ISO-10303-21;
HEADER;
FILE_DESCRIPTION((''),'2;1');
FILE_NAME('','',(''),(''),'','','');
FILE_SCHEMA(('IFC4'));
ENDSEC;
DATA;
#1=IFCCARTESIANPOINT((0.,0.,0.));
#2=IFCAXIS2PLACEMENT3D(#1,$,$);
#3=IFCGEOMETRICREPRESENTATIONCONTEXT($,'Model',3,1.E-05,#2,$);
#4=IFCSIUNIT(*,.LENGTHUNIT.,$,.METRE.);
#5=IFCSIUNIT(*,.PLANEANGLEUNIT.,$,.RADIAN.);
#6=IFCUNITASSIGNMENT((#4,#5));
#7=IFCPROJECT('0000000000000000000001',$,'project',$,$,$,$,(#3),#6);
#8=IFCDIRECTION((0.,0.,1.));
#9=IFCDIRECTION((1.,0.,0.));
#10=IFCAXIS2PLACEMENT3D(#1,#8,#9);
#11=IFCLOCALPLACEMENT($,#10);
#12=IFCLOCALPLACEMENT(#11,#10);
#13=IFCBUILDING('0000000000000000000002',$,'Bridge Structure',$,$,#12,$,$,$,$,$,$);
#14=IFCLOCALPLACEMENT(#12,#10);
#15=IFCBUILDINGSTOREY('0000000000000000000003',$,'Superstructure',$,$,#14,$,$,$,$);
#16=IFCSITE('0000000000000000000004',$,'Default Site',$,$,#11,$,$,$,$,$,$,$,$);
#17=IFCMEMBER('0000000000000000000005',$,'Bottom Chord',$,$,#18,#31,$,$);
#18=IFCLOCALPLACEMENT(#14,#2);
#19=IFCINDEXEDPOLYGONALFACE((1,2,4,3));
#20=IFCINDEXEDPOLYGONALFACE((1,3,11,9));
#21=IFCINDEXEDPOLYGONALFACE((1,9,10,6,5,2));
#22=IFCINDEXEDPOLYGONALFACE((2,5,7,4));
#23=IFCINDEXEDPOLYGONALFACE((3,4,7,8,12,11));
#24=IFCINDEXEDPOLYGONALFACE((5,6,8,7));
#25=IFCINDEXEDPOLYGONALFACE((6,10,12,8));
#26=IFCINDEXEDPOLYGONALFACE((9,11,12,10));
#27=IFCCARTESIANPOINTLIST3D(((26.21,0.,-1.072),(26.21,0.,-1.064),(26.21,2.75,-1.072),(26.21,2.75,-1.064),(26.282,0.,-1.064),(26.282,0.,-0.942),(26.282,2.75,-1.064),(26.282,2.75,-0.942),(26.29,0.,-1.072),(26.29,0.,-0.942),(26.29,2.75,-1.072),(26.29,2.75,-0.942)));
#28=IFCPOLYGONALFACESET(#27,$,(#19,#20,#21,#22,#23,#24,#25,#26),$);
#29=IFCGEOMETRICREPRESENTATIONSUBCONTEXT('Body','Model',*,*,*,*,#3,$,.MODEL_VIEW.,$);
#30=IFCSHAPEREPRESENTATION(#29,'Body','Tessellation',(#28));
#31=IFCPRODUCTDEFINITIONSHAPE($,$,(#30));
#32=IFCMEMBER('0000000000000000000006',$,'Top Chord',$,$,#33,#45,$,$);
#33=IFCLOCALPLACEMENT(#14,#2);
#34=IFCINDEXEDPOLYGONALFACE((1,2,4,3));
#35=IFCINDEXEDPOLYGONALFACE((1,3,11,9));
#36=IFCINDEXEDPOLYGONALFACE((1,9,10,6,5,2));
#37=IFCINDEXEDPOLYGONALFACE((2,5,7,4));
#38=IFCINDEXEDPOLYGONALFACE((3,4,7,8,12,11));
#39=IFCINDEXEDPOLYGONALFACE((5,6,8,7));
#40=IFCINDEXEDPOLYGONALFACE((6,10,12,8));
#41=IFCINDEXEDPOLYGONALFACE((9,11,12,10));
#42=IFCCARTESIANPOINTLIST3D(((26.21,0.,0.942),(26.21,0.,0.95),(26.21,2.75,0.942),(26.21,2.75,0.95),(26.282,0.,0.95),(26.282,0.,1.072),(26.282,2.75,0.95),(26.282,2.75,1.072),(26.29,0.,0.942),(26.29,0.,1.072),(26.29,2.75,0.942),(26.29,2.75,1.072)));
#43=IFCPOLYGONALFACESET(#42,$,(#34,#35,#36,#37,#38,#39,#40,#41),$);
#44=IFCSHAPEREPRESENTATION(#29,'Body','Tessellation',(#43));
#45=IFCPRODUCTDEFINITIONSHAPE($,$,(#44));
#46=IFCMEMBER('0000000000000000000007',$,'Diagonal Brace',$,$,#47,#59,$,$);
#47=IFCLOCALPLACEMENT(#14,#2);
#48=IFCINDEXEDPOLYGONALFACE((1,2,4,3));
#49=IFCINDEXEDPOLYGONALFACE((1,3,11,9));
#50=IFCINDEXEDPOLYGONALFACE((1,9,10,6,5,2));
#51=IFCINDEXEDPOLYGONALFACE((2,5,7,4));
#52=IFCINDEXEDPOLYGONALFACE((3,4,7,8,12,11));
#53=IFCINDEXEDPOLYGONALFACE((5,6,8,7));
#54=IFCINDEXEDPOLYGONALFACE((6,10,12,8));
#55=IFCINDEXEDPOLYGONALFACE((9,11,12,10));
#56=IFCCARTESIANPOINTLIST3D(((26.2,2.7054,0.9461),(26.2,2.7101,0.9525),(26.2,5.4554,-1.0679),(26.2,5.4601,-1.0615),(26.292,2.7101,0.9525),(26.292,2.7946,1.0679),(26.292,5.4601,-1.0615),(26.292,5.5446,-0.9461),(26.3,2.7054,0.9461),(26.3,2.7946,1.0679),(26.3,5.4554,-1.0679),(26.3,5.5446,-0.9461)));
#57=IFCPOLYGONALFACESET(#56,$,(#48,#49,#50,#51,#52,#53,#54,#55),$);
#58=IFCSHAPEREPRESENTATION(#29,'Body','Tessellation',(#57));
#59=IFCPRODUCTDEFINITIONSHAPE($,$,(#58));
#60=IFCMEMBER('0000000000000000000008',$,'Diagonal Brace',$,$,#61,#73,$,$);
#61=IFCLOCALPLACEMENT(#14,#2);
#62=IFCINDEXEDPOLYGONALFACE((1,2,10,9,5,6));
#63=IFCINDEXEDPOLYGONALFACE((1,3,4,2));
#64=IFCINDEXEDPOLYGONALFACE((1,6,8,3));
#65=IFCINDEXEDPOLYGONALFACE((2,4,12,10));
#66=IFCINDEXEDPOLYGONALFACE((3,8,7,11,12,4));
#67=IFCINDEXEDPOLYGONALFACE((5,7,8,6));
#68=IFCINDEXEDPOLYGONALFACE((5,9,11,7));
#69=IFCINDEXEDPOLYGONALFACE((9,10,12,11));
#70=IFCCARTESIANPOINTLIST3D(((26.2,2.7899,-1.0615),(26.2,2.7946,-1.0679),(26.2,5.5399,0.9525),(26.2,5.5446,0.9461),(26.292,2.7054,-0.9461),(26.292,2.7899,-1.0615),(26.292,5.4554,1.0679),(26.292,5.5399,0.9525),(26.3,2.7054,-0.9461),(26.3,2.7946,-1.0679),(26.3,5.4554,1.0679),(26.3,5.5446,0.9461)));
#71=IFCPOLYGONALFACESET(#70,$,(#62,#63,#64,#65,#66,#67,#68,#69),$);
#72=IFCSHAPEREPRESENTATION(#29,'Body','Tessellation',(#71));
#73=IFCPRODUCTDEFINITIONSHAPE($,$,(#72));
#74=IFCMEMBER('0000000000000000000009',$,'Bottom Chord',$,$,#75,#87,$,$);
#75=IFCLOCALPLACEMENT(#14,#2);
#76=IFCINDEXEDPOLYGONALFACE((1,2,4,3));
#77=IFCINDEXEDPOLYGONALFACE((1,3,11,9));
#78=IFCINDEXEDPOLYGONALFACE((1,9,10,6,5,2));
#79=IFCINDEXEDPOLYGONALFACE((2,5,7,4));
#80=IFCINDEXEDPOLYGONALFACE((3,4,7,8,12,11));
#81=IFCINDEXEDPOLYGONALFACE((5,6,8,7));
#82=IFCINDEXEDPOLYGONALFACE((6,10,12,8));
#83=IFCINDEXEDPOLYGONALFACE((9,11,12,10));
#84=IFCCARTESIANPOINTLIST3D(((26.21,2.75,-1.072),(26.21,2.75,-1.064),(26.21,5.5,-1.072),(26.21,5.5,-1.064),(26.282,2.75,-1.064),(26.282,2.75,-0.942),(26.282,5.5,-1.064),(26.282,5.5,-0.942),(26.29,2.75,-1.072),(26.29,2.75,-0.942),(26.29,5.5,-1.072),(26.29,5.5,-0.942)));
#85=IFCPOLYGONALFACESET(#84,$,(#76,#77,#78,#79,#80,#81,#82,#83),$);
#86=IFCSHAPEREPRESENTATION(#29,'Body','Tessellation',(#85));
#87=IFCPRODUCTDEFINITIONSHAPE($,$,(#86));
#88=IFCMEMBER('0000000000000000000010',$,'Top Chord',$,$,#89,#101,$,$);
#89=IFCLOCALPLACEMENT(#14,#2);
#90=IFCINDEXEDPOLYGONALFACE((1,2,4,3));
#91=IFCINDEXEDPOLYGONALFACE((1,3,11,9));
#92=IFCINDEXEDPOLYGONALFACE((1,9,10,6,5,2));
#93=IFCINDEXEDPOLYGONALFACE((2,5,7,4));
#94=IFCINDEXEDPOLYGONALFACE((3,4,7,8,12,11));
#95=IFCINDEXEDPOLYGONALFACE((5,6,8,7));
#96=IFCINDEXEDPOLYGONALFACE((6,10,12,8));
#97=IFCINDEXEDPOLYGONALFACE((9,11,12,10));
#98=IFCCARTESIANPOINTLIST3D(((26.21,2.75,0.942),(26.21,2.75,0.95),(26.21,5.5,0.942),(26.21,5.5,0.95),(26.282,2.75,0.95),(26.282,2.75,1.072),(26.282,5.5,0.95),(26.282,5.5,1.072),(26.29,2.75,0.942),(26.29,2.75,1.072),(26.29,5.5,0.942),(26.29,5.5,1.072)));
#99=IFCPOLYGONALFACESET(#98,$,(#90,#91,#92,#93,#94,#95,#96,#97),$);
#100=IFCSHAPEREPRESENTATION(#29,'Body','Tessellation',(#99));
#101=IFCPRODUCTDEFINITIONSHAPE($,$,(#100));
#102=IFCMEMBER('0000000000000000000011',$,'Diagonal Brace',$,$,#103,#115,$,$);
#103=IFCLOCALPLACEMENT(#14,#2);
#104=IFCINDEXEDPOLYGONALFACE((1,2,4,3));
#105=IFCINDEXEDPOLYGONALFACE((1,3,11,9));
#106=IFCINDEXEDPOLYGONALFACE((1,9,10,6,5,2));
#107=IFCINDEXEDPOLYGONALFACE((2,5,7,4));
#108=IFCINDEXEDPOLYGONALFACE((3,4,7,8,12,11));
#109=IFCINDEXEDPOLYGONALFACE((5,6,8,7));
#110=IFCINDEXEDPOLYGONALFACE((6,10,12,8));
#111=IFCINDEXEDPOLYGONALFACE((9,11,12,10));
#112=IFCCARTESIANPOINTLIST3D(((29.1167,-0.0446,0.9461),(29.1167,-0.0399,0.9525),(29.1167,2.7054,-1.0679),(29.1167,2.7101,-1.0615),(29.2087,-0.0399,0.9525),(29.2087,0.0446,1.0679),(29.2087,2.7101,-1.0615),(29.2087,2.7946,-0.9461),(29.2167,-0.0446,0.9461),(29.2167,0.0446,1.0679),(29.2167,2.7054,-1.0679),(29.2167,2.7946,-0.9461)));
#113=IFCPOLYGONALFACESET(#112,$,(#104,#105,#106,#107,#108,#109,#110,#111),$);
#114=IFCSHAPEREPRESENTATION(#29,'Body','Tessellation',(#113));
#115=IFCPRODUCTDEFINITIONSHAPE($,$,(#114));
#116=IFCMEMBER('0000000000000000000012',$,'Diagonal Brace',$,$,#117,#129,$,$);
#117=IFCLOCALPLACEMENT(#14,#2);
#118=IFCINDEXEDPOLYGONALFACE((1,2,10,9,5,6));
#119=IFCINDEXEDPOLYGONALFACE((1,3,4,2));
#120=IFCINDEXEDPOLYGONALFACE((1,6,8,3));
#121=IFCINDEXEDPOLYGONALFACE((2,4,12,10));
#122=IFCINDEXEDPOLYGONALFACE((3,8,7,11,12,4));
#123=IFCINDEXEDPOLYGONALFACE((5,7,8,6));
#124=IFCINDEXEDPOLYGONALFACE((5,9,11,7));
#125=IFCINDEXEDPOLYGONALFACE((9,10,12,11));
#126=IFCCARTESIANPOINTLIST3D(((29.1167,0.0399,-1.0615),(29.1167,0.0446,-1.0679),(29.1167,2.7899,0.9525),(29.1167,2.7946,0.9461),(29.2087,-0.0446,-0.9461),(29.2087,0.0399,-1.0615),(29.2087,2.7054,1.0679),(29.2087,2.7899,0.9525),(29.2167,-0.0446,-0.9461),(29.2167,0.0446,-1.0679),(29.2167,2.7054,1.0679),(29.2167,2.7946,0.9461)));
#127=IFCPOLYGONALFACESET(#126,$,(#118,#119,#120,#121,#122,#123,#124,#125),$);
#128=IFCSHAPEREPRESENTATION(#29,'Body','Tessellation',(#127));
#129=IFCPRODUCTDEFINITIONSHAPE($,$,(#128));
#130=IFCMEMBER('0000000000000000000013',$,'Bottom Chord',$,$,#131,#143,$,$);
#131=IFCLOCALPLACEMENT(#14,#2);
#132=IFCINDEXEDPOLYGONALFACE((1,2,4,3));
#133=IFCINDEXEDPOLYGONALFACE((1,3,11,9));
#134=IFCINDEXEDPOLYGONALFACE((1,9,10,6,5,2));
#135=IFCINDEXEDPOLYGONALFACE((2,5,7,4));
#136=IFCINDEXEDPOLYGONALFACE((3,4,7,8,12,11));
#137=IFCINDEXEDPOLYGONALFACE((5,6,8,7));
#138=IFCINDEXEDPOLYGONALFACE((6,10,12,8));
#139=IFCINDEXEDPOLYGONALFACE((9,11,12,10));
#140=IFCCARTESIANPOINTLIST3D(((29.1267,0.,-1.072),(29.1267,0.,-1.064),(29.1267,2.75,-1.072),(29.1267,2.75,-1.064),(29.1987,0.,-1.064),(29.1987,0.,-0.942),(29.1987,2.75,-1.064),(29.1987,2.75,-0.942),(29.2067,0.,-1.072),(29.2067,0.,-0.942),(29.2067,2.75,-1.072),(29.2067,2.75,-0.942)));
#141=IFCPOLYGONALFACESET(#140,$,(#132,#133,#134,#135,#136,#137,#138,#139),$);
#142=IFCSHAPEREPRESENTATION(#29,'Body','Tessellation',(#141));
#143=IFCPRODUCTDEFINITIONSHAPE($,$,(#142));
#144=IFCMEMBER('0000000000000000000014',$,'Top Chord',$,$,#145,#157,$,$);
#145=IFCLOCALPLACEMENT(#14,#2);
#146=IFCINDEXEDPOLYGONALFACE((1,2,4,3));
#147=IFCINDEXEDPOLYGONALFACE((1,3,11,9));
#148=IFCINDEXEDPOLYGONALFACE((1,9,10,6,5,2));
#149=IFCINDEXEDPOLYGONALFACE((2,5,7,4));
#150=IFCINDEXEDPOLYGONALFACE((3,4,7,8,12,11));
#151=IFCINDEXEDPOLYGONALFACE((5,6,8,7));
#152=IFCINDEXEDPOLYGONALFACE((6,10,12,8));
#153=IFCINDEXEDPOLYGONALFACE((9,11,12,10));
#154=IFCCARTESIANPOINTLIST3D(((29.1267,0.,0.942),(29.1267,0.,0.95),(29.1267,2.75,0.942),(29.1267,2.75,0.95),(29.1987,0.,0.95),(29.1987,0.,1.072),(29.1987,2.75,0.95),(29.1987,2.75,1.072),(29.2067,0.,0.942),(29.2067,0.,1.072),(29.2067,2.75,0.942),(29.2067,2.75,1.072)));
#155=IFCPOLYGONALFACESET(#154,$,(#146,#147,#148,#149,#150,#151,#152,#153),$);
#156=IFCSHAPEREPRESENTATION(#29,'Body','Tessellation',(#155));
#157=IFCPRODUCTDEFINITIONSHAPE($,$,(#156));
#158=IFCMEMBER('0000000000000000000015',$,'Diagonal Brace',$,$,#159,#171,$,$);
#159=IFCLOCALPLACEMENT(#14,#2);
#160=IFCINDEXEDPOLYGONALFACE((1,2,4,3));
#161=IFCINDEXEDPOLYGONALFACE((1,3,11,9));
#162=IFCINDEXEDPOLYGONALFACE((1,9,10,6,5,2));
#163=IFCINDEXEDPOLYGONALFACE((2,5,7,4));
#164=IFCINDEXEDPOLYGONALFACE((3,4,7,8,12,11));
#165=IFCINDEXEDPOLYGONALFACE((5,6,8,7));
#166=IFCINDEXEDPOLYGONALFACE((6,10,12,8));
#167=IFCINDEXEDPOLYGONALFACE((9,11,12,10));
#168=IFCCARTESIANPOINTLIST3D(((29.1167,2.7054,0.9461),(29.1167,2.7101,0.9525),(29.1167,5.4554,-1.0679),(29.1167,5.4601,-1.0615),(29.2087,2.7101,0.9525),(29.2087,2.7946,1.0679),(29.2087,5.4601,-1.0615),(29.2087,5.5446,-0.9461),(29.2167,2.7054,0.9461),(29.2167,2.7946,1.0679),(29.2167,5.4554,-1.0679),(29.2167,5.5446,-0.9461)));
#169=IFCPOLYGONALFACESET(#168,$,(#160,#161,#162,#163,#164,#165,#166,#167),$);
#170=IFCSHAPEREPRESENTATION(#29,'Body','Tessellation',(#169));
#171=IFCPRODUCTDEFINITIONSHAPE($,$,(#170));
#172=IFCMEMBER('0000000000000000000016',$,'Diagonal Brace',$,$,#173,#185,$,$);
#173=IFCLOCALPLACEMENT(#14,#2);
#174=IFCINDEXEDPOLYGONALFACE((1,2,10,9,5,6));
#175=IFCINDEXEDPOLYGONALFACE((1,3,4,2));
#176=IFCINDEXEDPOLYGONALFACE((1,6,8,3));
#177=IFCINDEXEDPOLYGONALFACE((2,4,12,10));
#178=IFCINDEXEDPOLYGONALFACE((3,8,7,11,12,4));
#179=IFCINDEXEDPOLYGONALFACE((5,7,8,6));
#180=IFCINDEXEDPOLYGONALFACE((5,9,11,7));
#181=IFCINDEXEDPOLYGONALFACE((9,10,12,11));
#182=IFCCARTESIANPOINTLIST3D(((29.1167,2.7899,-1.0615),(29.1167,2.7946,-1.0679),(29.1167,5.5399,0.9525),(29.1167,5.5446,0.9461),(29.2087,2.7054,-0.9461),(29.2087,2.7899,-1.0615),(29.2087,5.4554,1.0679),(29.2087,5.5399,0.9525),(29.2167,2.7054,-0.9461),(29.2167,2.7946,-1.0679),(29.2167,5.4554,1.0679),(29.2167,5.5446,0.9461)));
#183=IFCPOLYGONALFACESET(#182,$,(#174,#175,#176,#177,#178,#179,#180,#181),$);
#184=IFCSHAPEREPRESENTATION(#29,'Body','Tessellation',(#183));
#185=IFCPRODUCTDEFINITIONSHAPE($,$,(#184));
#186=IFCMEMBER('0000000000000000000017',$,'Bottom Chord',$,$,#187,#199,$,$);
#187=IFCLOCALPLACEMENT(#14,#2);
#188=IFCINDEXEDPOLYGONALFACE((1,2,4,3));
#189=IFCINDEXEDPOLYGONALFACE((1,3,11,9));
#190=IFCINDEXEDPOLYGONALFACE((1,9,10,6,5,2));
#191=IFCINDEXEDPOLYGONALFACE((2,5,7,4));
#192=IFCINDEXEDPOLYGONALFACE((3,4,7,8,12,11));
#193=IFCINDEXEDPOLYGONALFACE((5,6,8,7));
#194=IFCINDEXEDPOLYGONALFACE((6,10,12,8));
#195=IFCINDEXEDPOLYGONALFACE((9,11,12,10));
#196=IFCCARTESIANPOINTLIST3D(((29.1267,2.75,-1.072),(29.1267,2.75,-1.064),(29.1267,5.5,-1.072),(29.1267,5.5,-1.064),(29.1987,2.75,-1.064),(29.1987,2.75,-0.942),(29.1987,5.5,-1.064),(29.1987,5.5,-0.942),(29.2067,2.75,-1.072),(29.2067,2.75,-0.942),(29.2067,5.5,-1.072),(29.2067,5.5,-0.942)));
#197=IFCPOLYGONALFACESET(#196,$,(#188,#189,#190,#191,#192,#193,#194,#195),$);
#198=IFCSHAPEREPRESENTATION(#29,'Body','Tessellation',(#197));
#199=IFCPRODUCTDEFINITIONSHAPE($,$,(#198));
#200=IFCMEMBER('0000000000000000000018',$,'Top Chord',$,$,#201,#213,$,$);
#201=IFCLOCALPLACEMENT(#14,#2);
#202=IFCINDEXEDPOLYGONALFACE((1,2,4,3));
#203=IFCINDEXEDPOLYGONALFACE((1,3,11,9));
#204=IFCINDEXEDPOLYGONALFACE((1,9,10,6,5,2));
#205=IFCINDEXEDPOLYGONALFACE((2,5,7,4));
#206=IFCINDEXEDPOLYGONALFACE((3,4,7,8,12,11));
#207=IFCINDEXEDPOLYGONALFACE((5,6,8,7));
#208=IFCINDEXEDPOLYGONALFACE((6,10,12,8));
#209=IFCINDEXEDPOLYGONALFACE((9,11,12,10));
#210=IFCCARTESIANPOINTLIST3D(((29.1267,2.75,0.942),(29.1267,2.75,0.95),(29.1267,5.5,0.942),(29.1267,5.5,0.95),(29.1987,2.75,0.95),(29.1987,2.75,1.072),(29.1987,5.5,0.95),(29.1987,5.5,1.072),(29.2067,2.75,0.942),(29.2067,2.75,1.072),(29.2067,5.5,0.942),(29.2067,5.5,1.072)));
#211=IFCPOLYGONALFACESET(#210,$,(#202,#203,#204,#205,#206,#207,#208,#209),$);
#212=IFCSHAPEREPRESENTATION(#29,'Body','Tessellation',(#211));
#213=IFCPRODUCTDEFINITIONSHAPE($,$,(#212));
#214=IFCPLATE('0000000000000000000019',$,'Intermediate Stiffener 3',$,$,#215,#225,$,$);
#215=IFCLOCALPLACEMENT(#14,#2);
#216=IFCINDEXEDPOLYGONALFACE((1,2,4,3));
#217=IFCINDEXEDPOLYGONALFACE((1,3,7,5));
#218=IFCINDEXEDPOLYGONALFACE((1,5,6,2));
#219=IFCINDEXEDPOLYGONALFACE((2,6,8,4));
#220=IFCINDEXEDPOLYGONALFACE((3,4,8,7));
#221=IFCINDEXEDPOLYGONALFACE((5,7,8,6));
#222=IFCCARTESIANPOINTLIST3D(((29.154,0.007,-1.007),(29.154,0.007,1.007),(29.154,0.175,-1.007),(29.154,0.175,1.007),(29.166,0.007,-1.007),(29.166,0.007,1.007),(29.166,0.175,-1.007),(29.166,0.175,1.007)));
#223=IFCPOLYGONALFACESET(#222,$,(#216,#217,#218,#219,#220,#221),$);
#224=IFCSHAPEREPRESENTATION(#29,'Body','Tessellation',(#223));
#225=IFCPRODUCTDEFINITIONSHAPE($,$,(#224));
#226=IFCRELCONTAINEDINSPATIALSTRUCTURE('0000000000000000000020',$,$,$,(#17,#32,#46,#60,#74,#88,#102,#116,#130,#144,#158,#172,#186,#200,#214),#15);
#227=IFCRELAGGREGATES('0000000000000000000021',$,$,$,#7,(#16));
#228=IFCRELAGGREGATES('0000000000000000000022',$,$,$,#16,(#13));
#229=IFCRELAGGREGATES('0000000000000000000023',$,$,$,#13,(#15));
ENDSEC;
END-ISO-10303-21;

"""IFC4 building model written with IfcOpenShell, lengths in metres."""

from ifc_helpers import new_model, si_unit, frame, origin, origin_with_axes, origin_2d_with_axis, place, context, subcontext, project, spatial, rectangle, l_section, extrude, element, save


model = new_model("IFC4")

# Units and contexts
model_context = context("Model", 3, precision=1e-05, world=origin())
body_context = subcontext(model_context, "Body", "Model", "MODEL_VIEW")
ifc_project = project(units=[si_unit("LENGTHUNIT", "METRE"), si_unit("PLANEANGLEUNIT", "RADIAN")], contexts=[model_context])

# Site, building, storey
site_placement = place(None, origin_with_axes())
site = spatial("IfcSite", under=ifc_project, at=site_placement, Name="Default Site")
building_placement = place(site_placement, origin_with_axes())
building = spatial("IfcBuilding", under=site, at=building_placement, Name="Bridge Structure")
storey_placement = place(building_placement, origin_with_axes())
storey = spatial("IfcBuildingStorey", under=building, at=storey_placement, Name="Superstructure")

# Members
for number, where, z_axis, x_axis, name in (
    (1, (26.25, 0.0, -1.007), (0.0, 1.0, 0.0), (-1.0, 0.0, 0.0), "Bottom Chord"),
    (2, (26.25, 0.0, 1.007), (0.0, 1.0, 0.0), (-1.0, 0.0, 0.0), "Top Chord"),
):
    element("IfcMember", number, at=place(storey_placement, frame(where, z_axis=z_axis, x_axis=x_axis)), inside=storey, Name=name, context=body_context, shape_type="SweptSolid", body=[
        extrude(l_section(Depth=0.13, Width=0.08, Thickness=0.008, at=origin_2d_with_axis()), origin_with_axes(), (0.0, 0.0, 1.0), 2.75),
    ])
for number, where, z_axis, x_axis, name in (
    (3, (26.25, 2.75, 1.007), (0.0, 0.806778, -0.590855), (-1.0, 0.0, 0.0), "Diagonal Brace"),
    (4, (26.25, 2.75, -1.007), (0.0, 0.806778, 0.590855), (-1.0, 0.0, 0.0), "Diagonal Brace"),
):
    element("IfcMember", number, at=place(storey_placement, frame(where, z_axis=z_axis, x_axis=x_axis)), inside=storey, Name=name, context=body_context, shape_type="SweptSolid", body=[
        extrude(l_section(Depth=0.151, Width=0.1, Thickness=0.008, at=origin_2d_with_axis()), origin_with_axes(), (0.0, 0.0, 1.0), 3.4086),
    ])
for number, where, z_axis, x_axis, name in (
    (5, (26.25, 2.75, -1.007), (0.0, 1.0, 0.0), (-1.0, 0.0, 0.0), "Bottom Chord"),
    (6, (26.25, 2.75, 1.007), (0.0, 1.0, 0.0), (-1.0, 0.0, 0.0), "Top Chord"),
):
    element("IfcMember", number, at=place(storey_placement, frame(where, z_axis=z_axis, x_axis=x_axis)), inside=storey, Name=name, context=body_context, shape_type="SweptSolid", body=[
        extrude(l_section(Depth=0.13, Width=0.08, Thickness=0.008, at=origin_2d_with_axis()), origin_with_axes(), (0.0, 0.0, 1.0), 2.75),
    ])
for number, where, z_axis, x_axis, name in (
    (7, (29.1667, 0.0, 1.007), (0.0, 0.806778, -0.590855), (-1.0, 0.0, 0.0), "Diagonal Brace"),
    (8, (29.1667, 0.0, -1.007), (0.0, 0.806778, 0.590855), (-1.0, 0.0, 0.0), "Diagonal Brace"),
):
    element("IfcMember", number, at=place(storey_placement, frame(where, z_axis=z_axis, x_axis=x_axis)), inside=storey, Name=name, context=body_context, shape_type="SweptSolid", body=[
        extrude(l_section(Depth=0.151, Width=0.1, Thickness=0.008, at=origin_2d_with_axis()), origin_with_axes(), (0.0, 0.0, 1.0), 3.4086),
    ])
for number, where, z_axis, x_axis, name in (
    (9, (29.1667, 0.0, -1.007), (0.0, 1.0, 0.0), (-1.0, 0.0, 0.0), "Bottom Chord"),
    (10, (29.1667, 0.0, 1.007), (0.0, 1.0, 0.0), (-1.0, 0.0, 0.0), "Top Chord"),
):
    element("IfcMember", number, at=place(storey_placement, frame(where, z_axis=z_axis, x_axis=x_axis)), inside=storey, Name=name, context=body_context, shape_type="SweptSolid", body=[
        extrude(l_section(Depth=0.13, Width=0.08, Thickness=0.008, at=origin_2d_with_axis()), origin_with_axes(), (0.0, 0.0, 1.0), 2.75),
    ])
for number, where, z_axis, x_axis, name in (
    (11, (29.1667, 2.75, 1.007), (0.0, 0.806778, -0.590855), (-1.0, 0.0, 0.0), "Diagonal Brace"),
    (12, (29.1667, 2.75, -1.007), (0.0, 0.806778, 0.590855), (-1.0, 0.0, 0.0), "Diagonal Brace"),
):
    element("IfcMember", number, at=place(storey_placement, frame(where, z_axis=z_axis, x_axis=x_axis)), inside=storey, Name=name, context=body_context, shape_type="SweptSolid", body=[
        extrude(l_section(Depth=0.151, Width=0.1, Thickness=0.008, at=origin_2d_with_axis()), origin_with_axes(), (0.0, 0.0, 1.0), 3.4086),
    ])
for number, where, z_axis, x_axis, name in (
    (13, (29.1667, 2.75, -1.007), (0.0, 1.0, 0.0), (-1.0, 0.0, 0.0), "Bottom Chord"),
    (14, (29.1667, 2.75, 1.007), (0.0, 1.0, 0.0), (-1.0, 0.0, 0.0), "Top Chord"),
):
    element("IfcMember", number, at=place(storey_placement, frame(where, z_axis=z_axis, x_axis=x_axis)), inside=storey, Name=name, context=body_context, shape_type="SweptSolid", body=[
        extrude(l_section(Depth=0.13, Width=0.08, Thickness=0.008, at=origin_2d_with_axis()), origin_with_axes(), (0.0, 0.0, 1.0), 2.75),
    ])

# Plate
for number, where, z_axis, x_axis, name in (
    (15, (29.16, 0.091, -1.007), (0.0, 0.0, 1.0), (1.0, 0.0, 0.0), "Intermediate Stiffener 3"),
):
    element("IfcPlate", number, at=place(storey_placement, frame(where, z_axis=z_axis, x_axis=x_axis)), inside=storey, Name=name, context=body_context, shape_type="SweptSolid", body=[
        extrude(rectangle(XDim=0.012, YDim=0.168, at=origin_2d_with_axis()), origin_with_axes(), (0.0, 0.0, 1.0), 2.014),
    ])

save(model, "model.ifc")
